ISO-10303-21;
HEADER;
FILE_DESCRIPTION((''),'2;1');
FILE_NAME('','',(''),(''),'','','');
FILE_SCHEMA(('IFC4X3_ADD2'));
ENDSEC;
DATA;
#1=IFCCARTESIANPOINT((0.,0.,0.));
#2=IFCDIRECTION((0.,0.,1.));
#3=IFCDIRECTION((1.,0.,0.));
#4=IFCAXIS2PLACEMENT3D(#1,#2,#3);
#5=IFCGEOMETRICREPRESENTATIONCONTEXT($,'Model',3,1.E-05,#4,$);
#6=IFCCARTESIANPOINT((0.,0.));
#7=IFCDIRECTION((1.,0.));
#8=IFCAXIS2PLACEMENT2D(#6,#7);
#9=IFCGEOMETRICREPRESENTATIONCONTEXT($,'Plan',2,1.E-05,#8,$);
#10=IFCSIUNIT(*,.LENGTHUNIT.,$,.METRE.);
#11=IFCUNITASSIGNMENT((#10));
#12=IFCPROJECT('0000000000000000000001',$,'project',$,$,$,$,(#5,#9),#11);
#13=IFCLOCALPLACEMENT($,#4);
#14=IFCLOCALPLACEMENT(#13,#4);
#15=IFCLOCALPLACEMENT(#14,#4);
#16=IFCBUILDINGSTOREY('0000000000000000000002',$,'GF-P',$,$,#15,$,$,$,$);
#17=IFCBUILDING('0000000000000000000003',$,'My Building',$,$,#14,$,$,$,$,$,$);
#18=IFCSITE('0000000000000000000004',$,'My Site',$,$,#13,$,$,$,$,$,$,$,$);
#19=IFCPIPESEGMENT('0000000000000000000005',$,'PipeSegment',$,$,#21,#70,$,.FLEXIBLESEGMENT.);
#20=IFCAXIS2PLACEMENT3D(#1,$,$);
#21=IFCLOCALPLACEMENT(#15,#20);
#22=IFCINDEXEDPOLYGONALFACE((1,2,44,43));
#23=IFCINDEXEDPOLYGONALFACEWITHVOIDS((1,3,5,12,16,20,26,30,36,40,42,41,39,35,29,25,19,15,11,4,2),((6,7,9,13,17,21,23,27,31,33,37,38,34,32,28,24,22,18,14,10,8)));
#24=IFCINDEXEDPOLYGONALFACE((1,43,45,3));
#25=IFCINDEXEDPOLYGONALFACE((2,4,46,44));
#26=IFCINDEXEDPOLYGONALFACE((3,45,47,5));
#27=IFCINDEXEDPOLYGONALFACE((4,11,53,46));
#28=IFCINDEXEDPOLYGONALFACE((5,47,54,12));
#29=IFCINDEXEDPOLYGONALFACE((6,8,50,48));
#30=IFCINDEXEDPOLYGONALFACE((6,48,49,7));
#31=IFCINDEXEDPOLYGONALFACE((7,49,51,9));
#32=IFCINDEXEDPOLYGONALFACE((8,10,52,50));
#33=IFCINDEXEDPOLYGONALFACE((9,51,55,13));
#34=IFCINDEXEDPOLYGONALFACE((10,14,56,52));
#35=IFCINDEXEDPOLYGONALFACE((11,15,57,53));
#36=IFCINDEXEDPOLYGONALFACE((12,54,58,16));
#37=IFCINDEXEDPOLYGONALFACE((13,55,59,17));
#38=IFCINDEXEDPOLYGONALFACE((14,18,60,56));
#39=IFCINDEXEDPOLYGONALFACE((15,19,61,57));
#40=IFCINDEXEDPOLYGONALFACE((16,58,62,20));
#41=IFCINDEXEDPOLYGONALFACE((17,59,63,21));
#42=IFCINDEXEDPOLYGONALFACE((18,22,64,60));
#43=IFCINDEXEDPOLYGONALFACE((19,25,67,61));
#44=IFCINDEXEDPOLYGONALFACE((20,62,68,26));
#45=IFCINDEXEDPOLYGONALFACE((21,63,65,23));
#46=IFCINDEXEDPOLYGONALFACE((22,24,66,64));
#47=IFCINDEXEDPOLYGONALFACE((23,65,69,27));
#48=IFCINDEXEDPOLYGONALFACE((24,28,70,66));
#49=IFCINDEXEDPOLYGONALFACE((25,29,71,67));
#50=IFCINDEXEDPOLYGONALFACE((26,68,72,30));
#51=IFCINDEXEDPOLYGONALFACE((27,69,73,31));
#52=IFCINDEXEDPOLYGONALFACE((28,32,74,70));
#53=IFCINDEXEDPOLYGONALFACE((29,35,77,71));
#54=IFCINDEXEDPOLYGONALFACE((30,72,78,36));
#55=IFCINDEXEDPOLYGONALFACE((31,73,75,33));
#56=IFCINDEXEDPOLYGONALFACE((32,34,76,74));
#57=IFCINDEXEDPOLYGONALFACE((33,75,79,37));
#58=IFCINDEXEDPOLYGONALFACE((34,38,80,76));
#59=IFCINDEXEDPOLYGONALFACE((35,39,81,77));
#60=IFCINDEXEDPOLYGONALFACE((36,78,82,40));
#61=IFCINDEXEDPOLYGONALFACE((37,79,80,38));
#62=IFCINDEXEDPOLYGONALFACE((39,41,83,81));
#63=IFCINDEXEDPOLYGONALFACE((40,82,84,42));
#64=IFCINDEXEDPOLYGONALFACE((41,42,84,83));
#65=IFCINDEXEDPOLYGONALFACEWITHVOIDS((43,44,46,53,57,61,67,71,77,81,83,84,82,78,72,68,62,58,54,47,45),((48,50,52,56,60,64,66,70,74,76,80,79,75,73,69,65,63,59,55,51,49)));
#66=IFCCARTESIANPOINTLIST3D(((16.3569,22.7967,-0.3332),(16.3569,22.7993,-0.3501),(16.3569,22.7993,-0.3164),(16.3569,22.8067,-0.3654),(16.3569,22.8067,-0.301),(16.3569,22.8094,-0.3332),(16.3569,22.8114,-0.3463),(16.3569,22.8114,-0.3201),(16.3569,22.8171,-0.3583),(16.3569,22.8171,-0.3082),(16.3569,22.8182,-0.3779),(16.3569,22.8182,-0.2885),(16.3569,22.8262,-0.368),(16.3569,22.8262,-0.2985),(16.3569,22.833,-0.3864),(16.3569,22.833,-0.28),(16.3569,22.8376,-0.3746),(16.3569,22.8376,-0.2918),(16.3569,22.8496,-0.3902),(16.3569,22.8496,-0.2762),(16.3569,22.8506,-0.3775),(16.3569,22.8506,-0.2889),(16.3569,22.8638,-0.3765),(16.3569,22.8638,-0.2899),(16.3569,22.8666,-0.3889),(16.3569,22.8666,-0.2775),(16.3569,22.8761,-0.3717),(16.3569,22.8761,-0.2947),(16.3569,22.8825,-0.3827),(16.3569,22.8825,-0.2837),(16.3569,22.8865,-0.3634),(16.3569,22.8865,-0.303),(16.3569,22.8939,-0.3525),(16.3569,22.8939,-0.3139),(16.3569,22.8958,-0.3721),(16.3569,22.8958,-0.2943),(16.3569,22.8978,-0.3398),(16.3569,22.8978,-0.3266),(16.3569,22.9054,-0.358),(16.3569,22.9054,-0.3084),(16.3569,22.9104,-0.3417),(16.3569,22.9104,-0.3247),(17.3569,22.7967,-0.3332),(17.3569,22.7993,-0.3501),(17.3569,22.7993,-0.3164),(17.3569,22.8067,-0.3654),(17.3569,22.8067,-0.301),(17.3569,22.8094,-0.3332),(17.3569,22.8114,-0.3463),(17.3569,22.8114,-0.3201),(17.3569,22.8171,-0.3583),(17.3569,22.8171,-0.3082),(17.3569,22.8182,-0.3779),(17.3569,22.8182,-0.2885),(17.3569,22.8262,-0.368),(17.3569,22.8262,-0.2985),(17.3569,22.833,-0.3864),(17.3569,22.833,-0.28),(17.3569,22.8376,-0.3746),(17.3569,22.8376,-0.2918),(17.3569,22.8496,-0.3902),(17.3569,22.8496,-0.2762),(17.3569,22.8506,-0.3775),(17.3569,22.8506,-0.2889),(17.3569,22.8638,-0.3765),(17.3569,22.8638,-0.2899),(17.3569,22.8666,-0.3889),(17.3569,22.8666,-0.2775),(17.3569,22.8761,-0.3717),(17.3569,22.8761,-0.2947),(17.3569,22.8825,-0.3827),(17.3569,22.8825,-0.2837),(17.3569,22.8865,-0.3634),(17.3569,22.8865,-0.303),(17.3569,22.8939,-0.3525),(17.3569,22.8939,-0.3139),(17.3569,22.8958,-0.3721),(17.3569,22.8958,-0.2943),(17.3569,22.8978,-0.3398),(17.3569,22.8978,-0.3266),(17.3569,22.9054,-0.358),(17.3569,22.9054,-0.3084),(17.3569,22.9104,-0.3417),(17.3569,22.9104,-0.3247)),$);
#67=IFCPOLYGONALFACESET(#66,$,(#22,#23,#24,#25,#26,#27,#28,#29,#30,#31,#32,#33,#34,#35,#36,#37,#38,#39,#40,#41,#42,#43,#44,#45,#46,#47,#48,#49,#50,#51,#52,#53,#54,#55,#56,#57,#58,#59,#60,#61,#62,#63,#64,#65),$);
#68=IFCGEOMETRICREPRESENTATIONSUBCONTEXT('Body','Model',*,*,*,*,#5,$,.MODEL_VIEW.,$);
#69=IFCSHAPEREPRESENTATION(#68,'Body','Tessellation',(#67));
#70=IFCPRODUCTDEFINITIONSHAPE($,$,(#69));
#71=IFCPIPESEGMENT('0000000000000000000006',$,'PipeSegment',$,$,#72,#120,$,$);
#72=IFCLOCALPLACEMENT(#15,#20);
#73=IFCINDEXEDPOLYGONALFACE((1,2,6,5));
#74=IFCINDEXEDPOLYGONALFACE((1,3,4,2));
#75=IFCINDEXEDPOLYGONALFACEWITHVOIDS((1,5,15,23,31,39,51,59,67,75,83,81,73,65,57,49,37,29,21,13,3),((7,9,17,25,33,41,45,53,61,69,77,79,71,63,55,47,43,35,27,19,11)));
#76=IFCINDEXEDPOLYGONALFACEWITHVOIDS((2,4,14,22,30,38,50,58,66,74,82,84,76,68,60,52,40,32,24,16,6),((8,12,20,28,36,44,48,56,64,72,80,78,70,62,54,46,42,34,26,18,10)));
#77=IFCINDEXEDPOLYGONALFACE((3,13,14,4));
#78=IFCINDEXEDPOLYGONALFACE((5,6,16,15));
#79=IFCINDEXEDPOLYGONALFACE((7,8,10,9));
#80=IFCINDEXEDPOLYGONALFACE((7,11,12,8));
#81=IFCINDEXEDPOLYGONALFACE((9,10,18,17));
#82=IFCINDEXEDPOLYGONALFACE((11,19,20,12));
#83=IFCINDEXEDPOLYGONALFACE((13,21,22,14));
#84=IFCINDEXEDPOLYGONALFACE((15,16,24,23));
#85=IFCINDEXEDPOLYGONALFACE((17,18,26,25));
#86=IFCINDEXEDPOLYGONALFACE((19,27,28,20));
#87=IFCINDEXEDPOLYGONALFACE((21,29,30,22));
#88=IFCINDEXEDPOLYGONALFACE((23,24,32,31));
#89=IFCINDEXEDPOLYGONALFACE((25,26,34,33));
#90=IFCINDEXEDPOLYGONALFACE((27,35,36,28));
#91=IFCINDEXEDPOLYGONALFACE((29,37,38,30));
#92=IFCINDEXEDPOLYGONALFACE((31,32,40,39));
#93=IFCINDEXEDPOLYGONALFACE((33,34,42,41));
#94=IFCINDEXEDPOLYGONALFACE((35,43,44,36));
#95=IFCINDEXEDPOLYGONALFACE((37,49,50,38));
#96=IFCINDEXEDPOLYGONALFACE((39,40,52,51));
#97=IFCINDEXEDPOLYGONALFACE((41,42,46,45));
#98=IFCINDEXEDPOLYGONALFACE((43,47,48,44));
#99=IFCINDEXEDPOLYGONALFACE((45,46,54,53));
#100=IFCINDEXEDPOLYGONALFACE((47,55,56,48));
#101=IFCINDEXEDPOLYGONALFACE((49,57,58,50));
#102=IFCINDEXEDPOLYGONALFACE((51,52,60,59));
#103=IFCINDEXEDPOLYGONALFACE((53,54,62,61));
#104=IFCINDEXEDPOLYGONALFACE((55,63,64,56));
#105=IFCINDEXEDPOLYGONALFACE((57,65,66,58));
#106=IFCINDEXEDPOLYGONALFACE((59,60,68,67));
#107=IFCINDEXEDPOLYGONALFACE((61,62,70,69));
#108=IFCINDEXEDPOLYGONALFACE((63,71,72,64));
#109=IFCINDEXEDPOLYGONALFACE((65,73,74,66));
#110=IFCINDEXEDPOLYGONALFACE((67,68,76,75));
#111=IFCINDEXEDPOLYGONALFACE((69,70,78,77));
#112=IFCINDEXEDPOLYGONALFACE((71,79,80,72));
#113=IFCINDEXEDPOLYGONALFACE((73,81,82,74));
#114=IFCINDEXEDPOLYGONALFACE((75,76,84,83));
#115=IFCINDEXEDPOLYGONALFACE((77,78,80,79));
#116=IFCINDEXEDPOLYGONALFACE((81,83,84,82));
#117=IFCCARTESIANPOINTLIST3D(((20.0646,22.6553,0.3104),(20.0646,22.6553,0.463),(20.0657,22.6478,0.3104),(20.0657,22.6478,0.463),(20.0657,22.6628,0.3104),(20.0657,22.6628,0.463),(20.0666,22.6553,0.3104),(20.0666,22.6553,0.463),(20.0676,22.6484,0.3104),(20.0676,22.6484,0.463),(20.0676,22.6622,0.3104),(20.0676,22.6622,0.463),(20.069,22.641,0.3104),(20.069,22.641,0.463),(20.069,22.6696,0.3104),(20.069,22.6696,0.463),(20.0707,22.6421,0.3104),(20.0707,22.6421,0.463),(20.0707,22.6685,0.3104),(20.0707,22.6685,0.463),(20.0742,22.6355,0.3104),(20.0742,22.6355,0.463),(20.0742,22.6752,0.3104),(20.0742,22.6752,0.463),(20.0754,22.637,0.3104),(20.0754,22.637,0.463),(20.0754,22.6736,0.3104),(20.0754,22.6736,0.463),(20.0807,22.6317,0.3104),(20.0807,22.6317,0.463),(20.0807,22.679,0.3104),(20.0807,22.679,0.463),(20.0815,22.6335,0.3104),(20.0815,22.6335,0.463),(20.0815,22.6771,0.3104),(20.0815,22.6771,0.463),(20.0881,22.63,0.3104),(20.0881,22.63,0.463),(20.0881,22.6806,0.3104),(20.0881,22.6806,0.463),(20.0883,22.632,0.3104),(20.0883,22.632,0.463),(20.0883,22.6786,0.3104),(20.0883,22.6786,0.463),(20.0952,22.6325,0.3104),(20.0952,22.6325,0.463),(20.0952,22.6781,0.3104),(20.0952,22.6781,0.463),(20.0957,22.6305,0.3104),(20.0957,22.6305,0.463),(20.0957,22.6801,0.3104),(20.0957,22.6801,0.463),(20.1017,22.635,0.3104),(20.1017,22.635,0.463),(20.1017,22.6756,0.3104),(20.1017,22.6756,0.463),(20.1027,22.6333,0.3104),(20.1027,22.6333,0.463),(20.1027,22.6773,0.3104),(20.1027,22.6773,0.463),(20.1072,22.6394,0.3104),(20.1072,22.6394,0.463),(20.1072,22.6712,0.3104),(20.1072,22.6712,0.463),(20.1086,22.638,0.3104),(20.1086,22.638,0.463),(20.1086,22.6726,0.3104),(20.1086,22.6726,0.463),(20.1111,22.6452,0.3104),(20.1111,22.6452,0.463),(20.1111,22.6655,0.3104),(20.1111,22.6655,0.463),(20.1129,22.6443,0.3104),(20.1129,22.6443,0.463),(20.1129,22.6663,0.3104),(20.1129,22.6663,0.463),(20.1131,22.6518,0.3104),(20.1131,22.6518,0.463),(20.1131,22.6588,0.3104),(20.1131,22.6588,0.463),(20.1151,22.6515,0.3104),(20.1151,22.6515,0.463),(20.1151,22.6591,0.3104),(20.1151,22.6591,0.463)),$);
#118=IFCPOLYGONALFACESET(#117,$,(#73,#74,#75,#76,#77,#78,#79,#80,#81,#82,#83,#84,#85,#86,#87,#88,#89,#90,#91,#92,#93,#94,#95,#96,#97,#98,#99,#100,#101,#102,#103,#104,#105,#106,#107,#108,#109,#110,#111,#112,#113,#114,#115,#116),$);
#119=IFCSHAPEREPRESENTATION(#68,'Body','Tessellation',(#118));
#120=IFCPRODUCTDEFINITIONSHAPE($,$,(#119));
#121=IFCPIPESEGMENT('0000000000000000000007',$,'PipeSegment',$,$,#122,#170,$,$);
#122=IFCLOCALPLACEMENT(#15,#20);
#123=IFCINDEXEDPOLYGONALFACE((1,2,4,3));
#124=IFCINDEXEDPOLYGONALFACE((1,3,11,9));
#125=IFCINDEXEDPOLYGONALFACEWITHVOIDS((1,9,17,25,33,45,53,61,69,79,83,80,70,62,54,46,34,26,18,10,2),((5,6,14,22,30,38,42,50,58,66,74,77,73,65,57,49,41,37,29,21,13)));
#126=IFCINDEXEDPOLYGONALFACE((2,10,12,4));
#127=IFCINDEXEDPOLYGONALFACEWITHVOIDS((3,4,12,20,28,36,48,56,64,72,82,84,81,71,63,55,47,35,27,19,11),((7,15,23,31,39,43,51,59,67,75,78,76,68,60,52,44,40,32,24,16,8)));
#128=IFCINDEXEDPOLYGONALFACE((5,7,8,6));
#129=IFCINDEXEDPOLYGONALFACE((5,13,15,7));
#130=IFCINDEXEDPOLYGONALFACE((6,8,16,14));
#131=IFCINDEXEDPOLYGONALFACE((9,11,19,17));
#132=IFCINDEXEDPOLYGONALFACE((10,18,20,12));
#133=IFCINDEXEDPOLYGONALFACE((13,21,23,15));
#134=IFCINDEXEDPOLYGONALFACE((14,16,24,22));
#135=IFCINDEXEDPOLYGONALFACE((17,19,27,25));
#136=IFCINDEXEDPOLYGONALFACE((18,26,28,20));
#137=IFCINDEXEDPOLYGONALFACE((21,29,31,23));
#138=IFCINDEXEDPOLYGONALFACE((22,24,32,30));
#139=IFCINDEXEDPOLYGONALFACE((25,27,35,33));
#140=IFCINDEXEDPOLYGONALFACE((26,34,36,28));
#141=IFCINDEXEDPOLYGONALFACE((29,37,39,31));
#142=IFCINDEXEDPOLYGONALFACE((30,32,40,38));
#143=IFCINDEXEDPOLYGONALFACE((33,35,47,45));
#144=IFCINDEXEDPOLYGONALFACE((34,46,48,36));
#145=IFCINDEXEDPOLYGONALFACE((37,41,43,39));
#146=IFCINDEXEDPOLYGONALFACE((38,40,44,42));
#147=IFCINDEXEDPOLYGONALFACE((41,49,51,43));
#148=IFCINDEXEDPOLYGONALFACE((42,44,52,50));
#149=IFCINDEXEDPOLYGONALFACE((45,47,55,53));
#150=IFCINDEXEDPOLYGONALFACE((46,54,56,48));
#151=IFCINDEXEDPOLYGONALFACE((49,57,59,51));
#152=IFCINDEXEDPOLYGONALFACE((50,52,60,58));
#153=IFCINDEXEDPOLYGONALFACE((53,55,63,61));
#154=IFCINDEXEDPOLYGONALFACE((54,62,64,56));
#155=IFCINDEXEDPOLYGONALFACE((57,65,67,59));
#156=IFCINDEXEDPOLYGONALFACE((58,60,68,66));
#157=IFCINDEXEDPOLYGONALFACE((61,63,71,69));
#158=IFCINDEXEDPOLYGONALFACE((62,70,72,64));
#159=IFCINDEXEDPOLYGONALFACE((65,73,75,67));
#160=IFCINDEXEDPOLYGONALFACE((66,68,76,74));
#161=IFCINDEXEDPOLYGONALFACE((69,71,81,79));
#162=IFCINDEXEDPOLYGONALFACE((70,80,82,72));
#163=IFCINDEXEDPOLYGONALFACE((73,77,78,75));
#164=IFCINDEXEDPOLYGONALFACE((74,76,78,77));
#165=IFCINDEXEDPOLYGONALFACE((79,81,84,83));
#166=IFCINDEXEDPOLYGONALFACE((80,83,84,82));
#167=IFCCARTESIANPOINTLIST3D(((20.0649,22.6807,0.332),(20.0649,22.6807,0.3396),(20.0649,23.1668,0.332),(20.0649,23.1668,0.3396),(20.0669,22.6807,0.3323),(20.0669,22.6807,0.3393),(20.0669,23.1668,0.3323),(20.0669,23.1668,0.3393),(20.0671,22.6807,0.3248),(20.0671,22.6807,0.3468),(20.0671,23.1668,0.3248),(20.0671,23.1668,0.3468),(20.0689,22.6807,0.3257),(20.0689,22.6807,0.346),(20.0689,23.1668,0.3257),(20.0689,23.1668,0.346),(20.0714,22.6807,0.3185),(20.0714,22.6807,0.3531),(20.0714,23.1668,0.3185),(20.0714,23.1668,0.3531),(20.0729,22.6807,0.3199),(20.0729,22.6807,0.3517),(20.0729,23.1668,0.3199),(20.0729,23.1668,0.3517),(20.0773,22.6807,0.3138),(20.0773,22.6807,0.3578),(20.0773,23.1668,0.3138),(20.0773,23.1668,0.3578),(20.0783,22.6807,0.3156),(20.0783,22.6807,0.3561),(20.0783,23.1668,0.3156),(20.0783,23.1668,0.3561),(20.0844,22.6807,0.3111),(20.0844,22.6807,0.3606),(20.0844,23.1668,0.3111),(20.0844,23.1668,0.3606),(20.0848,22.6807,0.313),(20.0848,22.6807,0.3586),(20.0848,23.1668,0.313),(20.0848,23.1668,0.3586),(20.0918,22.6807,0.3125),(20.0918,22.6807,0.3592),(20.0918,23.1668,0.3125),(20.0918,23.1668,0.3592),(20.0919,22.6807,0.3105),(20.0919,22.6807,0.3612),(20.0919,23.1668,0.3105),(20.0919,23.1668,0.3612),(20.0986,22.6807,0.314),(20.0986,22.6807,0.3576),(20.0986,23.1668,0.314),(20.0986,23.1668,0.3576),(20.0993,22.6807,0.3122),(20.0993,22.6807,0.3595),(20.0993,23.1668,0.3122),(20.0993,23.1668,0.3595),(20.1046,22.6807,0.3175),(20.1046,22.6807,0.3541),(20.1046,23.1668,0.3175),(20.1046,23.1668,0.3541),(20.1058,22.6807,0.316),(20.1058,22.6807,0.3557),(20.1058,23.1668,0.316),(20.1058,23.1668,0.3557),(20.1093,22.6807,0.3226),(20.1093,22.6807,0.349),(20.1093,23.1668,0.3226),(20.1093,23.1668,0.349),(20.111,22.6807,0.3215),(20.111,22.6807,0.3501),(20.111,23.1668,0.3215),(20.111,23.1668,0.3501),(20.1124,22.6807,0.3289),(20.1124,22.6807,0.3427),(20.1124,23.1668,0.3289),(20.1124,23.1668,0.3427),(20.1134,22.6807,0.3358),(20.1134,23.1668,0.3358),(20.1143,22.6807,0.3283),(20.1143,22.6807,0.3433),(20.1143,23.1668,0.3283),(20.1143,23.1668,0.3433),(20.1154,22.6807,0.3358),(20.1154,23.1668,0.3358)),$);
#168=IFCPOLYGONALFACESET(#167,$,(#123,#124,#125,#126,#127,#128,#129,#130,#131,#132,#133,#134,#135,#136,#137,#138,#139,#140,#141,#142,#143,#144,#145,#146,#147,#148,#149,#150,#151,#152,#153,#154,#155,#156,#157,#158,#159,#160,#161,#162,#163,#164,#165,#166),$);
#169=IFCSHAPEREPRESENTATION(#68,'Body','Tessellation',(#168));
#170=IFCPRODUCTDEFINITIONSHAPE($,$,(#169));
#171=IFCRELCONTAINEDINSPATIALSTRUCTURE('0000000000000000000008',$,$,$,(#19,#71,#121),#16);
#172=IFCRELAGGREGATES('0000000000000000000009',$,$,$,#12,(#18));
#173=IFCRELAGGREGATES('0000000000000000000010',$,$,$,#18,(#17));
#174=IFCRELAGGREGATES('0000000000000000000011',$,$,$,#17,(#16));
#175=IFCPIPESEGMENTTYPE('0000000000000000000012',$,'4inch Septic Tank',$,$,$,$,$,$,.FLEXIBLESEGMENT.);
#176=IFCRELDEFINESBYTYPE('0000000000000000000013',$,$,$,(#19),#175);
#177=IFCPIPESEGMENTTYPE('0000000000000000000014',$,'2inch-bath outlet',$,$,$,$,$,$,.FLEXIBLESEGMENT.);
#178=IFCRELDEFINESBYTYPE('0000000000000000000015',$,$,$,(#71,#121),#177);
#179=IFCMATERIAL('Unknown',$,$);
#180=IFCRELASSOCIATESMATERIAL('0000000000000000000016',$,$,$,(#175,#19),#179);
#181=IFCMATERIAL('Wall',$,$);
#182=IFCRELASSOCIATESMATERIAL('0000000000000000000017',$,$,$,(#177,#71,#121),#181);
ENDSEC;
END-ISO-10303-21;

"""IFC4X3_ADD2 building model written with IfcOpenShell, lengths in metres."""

from ifc_helpers import new_model, si_unit, frame, origin_with_axes, origin_2d_with_axis, place, context, subcontext, project, spatial, hollow_circle, extrude, material, material_profile, profile_set, profile_usage, type_object, element, save


model = new_model("IFC4X3_ADD2")

# Units and contexts
model_context = context("Model", 3, precision=1e-05, world=origin_with_axes())
plan_context = context("Plan", 2, precision=1e-05, world=origin_2d_with_axis())
body_context = subcontext(model_context, "Body", "Model", "MODEL_VIEW")
ifc_project = project(units=[si_unit("LENGTHUNIT", "METRE")], contexts=[model_context, plan_context])

# Site, building, storey
site_placement = place(None, origin_with_axes())
site = spatial("IfcSite", under=ifc_project, at=site_placement, Name="My Site")
building_placement = place(site_placement, origin_with_axes())
building = spatial("IfcBuilding", under=site, at=building_placement, Name="My Building")
storey_placement = place(building_placement, origin_with_axes())
storey = spatial("IfcBuildingStorey", under=building, at=storey_placement, Name="GF-P")

# Pipe segments
ifc_material_1 = material(Name="Unknown")
ifc_material_profile_1 = material_profile(ifc_material_1, hollow_circle(Radius=0.0571, WallThickness=0.0127))
ifc_profile_set_1 = profile_set([ifc_material_profile_1], Name="blackwater")
pipe_segment_type_1 = type_object("IfcPipeSegmentType", Name="4inch Septic Tank", PredefinedType="FLEXIBLESEGMENT", material=ifc_profile_set_1)
ifc_profile_usage_1 = profile_usage(ifc_profile_set_1, cardinal=5)
pipe_segment_1_placement = place(storey_placement, frame((17.3569, 22.8539, -0.3332), z_axis=(-1.0, 0.0, 0.0), x_axis=(0.0, -1.0, 0.0)))
element("IfcPipeSegment", 1, at=pipe_segment_1_placement, inside=storey, type_object=pipe_segment_type_1, material=ifc_profile_usage_1, Name="PipeSegment", PredefinedType="FLEXIBLESEGMENT", context=body_context, shape_type="SweptSolid", body=[
    extrude(hollow_circle(Radius=0.0571, WallThickness=0.0127), origin_with_axes(), (0.0, 0.0, 1.0), 1.0),
])
ifc_material_2 = material(Name="Wall")
ifc_material_profile_2 = material_profile(ifc_material_2, hollow_circle(Radius=0.0254, WallThickness=0.002))
ifc_profile_set_2 = profile_set([ifc_material_profile_2], Name="graywater")
ifc_profile_usage_2 = profile_usage(ifc_profile_set_2)
pipe_segment_type_2 = type_object("IfcPipeSegmentType", Name="2inch-bath outlet", PredefinedType="FLEXIBLESEGMENT", material=ifc_profile_set_2)
pipe_segment_2_placement = place(storey_placement, frame((20.09, 22.6553, 0.3104), z_axis=(0.0, 0.0, 1.0), x_axis=(-1.0, 0.0, 0.0)))
element("IfcPipeSegment", 2, at=pipe_segment_2_placement, inside=storey, type_object=pipe_segment_type_2, material=ifc_profile_usage_2, Name="PipeSegment", context=body_context, shape_type="SweptSolid", body=[
    extrude(hollow_circle(Radius=0.0254, WallThickness=0.002), origin_with_axes(), (0.0, 0.0, 1.0), 0.1525),
])
ifc_profile_usage_3 = profile_usage(ifc_profile_set_2)
pipe_segment_3_placement = place(storey_placement, frame((20.09, 23.1668, 0.3358), z_axis=(0.0, -1.0, 0.0), x_axis=(1.0, 0.0, 0.0)))
element("IfcPipeSegment", 3, at=pipe_segment_3_placement, inside=storey, type_object=pipe_segment_type_2, material=ifc_profile_usage_3, Name="PipeSegment", context=body_context, shape_type="SweptSolid", body=[
    extrude(hollow_circle(Radius=0.0254, WallThickness=0.002), origin_with_axes(), (0.0, 0.0, 1.0), 0.4861),
])

save(model, "model.ifc")
